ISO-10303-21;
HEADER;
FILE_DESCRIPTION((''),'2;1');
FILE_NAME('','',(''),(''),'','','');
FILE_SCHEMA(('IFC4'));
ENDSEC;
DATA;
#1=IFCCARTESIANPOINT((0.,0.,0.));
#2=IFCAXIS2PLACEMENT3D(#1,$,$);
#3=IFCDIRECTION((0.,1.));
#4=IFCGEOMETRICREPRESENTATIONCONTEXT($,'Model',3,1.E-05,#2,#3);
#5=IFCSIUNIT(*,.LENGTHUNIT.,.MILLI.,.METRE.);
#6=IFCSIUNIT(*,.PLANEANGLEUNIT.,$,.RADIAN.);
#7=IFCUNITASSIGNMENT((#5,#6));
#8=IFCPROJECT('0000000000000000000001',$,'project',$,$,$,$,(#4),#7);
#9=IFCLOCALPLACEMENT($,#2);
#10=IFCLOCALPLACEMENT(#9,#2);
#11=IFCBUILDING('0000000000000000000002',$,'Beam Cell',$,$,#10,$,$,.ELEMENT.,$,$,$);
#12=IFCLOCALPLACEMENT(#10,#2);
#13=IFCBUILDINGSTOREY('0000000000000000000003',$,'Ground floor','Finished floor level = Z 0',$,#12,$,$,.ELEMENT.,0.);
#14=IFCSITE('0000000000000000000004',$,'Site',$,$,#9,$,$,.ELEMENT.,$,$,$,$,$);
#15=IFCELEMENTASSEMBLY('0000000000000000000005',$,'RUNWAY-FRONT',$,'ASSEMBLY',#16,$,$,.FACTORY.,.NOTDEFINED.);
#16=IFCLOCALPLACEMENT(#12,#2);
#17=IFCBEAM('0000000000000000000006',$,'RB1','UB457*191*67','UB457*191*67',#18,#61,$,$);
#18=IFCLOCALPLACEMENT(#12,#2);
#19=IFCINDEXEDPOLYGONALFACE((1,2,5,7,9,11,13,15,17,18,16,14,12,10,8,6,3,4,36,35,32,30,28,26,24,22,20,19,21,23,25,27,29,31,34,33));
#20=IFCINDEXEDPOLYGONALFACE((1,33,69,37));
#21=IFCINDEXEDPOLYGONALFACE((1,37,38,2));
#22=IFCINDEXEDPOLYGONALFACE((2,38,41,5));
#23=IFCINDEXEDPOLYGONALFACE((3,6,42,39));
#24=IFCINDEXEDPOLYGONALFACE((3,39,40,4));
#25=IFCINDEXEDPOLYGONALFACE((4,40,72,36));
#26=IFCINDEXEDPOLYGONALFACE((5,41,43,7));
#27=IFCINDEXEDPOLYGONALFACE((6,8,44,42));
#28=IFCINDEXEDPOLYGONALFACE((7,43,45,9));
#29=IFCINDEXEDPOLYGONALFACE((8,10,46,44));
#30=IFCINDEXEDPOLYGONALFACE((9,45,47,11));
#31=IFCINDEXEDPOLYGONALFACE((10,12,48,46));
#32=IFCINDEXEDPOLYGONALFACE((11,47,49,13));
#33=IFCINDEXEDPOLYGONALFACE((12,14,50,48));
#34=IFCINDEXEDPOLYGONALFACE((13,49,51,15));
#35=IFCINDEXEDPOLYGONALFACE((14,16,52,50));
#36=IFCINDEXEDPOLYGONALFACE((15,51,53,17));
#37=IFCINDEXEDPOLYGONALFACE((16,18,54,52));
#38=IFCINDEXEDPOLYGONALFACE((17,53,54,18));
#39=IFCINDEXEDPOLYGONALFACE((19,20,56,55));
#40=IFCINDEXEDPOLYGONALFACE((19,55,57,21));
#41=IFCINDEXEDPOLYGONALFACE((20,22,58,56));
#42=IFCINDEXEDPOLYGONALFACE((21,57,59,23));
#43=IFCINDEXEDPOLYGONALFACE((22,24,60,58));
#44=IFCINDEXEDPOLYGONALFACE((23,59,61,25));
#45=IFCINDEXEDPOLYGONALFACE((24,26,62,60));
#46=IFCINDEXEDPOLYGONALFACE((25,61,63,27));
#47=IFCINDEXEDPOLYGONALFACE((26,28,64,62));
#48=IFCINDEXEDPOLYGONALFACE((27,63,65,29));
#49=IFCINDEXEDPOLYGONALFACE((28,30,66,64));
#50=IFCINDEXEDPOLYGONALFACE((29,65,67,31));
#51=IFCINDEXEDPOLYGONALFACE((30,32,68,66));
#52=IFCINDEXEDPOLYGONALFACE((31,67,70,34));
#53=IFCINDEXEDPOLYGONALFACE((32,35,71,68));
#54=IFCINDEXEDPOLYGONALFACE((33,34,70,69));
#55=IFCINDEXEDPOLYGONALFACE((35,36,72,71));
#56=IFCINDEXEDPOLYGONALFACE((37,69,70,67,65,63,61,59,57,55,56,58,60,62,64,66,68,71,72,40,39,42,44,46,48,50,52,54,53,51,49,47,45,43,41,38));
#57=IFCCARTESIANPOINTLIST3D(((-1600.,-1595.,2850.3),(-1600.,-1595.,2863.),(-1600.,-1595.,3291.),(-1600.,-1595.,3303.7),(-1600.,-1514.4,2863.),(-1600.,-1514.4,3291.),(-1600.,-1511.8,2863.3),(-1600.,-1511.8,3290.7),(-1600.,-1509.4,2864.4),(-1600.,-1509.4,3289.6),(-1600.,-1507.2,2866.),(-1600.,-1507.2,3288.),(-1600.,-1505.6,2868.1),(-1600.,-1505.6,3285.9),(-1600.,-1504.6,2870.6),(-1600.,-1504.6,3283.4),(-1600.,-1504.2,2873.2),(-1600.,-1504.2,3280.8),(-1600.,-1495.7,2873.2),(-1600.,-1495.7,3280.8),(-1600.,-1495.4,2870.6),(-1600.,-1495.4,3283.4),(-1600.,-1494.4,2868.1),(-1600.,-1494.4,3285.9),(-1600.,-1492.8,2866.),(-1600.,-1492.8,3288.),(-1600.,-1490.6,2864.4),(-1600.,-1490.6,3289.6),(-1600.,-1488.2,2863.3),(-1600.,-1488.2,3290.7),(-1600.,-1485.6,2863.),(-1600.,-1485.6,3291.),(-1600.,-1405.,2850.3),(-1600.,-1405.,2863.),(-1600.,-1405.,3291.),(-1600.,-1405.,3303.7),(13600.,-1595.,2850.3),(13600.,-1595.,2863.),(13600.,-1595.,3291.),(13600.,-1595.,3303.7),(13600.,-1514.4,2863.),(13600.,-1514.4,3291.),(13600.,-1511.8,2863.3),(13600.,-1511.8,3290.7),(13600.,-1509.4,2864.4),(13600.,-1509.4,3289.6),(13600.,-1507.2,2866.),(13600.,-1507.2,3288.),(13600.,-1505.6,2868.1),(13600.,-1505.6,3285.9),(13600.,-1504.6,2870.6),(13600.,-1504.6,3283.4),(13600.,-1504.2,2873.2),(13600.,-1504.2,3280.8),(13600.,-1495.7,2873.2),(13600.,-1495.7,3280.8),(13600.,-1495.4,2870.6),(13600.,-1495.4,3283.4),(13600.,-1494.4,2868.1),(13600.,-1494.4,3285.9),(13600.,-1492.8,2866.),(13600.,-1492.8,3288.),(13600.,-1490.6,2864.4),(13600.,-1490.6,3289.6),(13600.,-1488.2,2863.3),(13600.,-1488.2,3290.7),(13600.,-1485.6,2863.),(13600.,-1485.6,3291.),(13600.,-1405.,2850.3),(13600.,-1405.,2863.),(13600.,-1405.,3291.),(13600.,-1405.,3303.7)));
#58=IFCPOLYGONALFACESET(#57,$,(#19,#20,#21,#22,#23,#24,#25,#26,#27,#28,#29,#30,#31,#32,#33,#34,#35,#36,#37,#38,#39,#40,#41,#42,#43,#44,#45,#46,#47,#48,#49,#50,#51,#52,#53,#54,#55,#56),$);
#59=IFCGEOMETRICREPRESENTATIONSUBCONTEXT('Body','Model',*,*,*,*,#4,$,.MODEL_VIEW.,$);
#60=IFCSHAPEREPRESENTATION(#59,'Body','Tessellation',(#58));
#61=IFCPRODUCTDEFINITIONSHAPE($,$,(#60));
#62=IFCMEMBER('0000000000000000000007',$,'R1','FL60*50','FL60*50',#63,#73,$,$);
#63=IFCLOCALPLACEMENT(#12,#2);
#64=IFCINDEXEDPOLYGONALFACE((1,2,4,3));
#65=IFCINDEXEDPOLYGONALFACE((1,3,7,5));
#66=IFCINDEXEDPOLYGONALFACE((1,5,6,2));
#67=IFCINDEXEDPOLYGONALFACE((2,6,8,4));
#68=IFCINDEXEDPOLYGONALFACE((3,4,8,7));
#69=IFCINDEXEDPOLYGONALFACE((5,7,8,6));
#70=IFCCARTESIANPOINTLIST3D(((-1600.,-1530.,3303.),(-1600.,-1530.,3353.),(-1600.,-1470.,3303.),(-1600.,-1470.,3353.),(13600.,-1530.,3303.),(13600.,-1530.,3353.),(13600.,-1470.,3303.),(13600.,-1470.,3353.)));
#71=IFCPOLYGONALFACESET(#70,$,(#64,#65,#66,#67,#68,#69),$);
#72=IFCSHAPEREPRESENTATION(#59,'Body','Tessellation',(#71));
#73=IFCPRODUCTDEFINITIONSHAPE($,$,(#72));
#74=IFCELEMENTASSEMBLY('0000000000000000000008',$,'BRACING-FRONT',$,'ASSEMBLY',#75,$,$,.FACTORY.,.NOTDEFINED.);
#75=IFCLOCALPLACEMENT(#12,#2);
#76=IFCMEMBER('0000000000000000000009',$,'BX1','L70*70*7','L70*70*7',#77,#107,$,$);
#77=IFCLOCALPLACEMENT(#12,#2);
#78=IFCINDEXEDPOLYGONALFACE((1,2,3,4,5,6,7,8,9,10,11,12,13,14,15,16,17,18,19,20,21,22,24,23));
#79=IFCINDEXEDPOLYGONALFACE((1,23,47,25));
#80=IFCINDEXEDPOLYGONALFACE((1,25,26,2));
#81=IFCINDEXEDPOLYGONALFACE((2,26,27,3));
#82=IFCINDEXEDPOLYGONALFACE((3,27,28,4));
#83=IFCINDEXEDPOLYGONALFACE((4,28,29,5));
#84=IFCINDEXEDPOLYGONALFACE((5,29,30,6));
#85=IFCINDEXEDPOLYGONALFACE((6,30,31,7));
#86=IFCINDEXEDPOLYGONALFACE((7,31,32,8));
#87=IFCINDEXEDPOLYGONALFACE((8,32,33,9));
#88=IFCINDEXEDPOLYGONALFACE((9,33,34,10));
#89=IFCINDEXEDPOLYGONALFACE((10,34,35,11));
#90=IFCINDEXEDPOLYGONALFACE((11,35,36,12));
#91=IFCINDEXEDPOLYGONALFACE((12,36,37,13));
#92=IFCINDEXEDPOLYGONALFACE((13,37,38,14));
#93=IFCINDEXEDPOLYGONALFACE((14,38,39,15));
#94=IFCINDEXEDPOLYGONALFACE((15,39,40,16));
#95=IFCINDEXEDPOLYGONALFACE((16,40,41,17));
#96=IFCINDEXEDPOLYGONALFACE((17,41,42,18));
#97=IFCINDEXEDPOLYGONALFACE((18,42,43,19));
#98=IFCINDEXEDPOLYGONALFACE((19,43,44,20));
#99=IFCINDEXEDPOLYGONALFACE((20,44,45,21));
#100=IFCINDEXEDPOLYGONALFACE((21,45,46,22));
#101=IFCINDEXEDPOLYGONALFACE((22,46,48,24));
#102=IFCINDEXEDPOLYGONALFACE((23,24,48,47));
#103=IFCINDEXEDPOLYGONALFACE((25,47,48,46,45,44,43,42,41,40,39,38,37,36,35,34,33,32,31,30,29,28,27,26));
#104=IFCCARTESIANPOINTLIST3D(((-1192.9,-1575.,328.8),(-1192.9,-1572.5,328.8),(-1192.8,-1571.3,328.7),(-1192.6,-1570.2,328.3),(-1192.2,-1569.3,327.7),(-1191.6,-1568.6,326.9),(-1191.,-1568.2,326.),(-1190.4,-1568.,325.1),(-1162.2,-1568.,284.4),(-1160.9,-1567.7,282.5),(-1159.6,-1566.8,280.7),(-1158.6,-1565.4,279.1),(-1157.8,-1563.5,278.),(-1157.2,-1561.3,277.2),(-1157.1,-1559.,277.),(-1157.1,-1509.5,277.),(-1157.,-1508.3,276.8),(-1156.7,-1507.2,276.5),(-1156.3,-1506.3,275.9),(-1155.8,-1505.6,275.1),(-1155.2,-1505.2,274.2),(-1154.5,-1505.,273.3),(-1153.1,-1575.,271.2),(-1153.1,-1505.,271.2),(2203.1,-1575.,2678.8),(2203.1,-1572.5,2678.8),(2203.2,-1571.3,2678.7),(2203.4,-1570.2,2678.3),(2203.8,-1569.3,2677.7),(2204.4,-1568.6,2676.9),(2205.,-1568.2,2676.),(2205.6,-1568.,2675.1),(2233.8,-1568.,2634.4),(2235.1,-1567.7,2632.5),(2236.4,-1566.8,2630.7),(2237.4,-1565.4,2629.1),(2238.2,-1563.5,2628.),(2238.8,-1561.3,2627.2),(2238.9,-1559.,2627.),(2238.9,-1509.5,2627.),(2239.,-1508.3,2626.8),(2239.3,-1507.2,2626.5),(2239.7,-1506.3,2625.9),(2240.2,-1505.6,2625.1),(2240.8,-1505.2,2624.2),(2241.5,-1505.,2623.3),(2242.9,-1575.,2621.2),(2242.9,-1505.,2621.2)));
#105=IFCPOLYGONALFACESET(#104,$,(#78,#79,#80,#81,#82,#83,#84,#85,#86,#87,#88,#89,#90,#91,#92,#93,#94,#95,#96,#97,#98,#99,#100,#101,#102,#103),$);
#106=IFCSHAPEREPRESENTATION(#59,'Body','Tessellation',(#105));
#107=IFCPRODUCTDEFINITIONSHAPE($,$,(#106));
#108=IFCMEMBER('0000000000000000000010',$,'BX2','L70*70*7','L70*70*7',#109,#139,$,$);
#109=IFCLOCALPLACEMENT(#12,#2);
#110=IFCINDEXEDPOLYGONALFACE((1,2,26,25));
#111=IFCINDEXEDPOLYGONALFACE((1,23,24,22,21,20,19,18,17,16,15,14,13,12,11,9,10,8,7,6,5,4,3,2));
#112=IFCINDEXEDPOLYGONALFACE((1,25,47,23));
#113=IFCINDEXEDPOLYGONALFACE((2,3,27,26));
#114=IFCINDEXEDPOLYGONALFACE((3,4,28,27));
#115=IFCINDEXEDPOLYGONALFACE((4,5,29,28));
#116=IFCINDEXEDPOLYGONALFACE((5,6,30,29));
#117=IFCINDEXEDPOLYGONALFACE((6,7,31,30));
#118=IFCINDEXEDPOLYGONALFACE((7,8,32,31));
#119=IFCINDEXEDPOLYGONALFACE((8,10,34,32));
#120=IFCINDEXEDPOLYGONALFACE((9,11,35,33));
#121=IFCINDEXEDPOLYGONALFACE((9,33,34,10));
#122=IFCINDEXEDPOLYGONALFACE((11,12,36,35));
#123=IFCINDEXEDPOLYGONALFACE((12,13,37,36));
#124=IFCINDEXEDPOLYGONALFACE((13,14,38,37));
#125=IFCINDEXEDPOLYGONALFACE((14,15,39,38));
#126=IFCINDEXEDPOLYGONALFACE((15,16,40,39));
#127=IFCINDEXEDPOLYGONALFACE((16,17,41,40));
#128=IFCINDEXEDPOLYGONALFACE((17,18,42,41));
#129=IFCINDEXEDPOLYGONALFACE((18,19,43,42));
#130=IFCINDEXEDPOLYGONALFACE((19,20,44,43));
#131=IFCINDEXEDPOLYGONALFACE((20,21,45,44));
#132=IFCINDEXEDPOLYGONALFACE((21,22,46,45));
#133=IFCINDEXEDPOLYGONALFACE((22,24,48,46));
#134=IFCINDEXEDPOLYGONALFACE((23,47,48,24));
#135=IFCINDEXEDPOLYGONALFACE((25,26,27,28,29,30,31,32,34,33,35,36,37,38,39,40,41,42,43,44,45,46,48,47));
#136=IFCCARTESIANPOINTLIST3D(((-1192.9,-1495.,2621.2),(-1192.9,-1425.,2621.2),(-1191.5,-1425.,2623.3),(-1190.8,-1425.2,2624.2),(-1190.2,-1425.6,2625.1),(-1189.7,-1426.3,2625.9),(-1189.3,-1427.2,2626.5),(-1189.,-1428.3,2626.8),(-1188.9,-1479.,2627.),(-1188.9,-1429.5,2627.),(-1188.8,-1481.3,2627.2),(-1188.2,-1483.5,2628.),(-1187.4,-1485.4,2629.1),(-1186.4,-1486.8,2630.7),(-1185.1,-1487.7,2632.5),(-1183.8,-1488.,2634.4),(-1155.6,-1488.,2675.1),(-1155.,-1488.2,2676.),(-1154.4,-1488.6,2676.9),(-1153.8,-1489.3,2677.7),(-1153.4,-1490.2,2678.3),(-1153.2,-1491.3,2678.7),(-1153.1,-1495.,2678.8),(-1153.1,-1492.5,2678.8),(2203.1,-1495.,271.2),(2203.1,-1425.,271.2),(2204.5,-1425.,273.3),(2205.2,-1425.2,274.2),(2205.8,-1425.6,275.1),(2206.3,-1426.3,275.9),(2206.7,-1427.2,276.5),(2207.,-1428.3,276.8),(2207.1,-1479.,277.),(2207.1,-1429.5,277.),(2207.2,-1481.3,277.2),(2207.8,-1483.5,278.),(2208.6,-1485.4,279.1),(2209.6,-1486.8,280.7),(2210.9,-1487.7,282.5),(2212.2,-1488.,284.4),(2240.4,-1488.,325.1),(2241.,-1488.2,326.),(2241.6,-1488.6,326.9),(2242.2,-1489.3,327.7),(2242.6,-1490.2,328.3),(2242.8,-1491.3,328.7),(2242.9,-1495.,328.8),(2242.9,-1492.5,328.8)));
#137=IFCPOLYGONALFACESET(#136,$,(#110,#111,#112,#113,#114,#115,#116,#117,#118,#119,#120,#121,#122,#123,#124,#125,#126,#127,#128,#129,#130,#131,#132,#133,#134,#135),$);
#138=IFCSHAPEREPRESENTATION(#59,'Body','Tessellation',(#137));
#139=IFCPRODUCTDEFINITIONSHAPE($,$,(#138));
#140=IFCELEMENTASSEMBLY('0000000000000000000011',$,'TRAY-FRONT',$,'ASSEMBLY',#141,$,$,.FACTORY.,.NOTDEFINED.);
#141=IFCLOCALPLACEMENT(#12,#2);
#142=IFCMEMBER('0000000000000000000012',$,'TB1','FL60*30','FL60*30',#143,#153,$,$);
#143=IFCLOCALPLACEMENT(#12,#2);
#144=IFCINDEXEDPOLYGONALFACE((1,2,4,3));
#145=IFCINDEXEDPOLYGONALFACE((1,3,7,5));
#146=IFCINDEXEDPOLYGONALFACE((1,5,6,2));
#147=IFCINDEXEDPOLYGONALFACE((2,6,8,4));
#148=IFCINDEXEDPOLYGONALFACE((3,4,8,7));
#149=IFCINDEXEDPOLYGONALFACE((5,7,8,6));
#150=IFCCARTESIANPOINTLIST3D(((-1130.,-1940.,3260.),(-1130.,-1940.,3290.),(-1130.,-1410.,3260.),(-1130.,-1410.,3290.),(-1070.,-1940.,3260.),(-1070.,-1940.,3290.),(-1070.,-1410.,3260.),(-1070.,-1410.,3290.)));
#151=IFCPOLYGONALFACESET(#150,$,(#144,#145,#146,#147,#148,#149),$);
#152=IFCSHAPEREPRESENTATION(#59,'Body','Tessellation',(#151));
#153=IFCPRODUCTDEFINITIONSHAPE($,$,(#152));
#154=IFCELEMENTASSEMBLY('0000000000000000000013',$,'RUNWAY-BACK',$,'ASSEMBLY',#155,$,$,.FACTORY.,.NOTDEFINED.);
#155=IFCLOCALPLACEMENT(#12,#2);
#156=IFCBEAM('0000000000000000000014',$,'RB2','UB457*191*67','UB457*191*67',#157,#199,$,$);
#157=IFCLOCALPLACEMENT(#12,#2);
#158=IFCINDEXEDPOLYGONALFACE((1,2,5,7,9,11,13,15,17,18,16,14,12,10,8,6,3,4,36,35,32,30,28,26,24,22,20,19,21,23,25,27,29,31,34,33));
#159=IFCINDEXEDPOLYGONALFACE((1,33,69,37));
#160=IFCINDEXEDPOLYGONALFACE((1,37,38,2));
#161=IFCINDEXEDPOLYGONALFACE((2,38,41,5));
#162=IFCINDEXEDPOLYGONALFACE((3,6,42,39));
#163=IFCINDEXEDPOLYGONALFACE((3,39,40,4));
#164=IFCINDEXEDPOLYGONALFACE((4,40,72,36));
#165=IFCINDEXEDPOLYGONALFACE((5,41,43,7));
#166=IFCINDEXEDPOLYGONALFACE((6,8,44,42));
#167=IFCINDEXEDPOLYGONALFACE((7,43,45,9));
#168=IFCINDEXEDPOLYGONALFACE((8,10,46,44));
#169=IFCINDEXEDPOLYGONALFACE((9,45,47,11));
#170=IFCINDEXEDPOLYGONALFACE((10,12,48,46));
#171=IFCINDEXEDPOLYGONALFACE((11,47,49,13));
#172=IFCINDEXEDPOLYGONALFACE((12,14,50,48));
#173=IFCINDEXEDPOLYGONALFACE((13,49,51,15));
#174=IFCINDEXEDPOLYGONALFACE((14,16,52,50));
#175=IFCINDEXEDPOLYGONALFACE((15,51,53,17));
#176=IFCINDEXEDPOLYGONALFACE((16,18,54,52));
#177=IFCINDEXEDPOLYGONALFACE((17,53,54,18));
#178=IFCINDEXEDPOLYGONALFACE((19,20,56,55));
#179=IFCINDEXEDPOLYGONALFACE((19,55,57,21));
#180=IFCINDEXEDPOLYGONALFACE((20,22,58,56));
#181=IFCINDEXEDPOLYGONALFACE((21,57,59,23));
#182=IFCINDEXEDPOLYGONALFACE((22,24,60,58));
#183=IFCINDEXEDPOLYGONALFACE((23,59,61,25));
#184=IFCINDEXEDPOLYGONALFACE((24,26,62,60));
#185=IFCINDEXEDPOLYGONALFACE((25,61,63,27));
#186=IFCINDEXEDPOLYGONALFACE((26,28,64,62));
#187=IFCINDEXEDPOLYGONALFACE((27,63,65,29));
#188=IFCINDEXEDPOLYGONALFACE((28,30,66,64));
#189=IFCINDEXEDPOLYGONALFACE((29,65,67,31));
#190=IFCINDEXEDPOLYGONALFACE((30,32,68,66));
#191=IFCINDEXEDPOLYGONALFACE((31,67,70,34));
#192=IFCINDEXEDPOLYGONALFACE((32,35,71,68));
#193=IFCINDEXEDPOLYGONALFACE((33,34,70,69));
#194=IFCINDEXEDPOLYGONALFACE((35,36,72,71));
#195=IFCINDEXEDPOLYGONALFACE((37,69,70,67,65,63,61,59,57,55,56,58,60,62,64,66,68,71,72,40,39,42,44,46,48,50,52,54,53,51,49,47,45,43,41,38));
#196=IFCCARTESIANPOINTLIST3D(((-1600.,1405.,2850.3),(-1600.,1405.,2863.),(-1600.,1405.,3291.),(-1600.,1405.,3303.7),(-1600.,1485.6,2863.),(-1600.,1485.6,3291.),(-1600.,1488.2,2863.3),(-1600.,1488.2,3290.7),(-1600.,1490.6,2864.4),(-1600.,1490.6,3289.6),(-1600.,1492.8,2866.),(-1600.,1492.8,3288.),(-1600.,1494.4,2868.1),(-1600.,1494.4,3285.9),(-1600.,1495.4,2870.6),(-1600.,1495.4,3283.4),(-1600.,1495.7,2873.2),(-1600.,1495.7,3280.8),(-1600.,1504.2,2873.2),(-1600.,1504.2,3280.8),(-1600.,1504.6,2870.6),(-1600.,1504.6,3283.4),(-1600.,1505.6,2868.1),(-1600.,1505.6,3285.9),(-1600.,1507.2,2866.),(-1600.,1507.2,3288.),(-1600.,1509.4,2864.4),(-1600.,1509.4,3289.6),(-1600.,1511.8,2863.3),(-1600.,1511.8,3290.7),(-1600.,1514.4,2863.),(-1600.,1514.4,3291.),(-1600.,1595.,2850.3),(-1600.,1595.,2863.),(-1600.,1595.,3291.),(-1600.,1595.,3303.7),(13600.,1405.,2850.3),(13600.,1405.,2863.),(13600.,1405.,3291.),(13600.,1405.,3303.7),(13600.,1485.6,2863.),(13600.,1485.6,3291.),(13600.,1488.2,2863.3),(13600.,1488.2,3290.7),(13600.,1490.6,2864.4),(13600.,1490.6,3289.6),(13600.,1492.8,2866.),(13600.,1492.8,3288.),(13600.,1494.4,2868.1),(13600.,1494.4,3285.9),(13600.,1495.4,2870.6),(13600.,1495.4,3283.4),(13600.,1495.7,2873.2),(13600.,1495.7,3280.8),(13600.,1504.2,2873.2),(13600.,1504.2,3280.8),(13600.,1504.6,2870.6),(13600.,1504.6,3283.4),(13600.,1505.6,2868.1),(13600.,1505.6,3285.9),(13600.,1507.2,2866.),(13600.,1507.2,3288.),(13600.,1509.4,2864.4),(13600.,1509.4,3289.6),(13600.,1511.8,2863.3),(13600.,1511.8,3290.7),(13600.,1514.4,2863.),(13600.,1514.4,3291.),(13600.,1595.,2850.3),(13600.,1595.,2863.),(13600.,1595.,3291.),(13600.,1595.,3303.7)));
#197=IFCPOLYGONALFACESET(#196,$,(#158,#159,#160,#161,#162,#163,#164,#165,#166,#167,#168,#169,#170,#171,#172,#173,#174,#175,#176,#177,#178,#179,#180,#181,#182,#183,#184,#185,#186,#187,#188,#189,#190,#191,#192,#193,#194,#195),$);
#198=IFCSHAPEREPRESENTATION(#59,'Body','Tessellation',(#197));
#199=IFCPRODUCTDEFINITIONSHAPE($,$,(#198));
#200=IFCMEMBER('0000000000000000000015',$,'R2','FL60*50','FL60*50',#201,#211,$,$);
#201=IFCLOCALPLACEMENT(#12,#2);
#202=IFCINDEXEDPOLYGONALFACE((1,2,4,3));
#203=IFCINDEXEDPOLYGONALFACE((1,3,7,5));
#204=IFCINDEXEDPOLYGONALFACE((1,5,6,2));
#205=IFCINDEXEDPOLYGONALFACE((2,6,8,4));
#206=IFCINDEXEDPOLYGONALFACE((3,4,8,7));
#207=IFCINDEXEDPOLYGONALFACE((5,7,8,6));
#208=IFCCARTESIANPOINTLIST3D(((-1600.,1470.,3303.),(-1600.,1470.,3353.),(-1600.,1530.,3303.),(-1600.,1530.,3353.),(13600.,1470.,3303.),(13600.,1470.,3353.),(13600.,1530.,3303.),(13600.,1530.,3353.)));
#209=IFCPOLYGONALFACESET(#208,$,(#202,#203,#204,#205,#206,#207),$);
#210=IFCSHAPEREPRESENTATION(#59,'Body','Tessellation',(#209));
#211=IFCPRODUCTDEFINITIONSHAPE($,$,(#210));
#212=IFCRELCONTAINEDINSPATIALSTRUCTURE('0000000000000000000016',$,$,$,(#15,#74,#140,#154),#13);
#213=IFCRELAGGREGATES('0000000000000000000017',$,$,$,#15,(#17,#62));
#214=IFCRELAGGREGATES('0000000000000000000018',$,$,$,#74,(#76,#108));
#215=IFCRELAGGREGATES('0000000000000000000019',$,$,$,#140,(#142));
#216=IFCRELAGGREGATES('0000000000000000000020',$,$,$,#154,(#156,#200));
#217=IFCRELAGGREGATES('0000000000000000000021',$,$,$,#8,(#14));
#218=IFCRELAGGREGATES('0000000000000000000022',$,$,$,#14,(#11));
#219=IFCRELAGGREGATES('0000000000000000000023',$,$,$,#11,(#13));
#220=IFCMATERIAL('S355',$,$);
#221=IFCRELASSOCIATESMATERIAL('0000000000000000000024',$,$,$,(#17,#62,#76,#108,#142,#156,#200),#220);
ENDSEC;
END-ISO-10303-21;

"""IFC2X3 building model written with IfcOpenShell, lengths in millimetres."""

from ifc_helpers import new_model, si_unit, direction, frame, origin, origin_2d, place, context, subcontext, project, spatial, rectangle, i_section, l_section, extrude, material, element, aggregate, save


model = new_model("IFC2X3")

# Units and contexts
model_context = context("Model", 3, precision=1e-05, world=origin(), true_north=direction((0.0, 1.0)))
body_context = subcontext(model_context, "Body", "Model", "MODEL_VIEW")
ifc_project = project(units=[si_unit("LENGTHUNIT", "METRE", prefix="MILLI"), si_unit("PLANEANGLEUNIT", "RADIAN")], contexts=[model_context])

# Site, building, storey
site_placement = place(None, origin())
site = spatial("IfcSite", under=ifc_project, at=site_placement, Name="Site", CompositionType="ELEMENT")
building_placement = place(site_placement, origin())
building = spatial("IfcBuilding", under=site, at=building_placement, Name="Beam Cell", CompositionType="ELEMENT")
storey_placement = place(building_placement, origin())
storey = spatial("IfcBuildingStorey", under=building, at=storey_placement, Name="Ground floor", Description="Finished floor level = Z 0", CompositionType="ELEMENT", Elevation=0.0)

# Shared definitions
ifc_material = material(Name="S355")

# Element assembly, beam, member
assembly_1_placement = place(storey_placement, origin())
assembly_1 = element("IfcElementAssembly", 1, at=assembly_1_placement, inside=storey, Name="RUNWAY-FRONT", ObjectType="ASSEMBLY", AssemblyPlace="FACTORY", PredefinedType="NOTDEFINED")
beam_1_placement = place(storey_placement, frame((-1600.0, -1500.0, 3077.0), z_axis=(1.0, 0.0, 0.0), x_axis=(0.0, 1.0, 0.0)))
beam_1 = element("IfcBeam", 2, at=beam_1_placement, material=ifc_material, Name="RB1", Description="UB457*191*67", ObjectType="UB457*191*67", context=body_context, shape_type="SweptSolid", body=[
    extrude(i_section(OverallWidth=189.9, OverallDepth=453.4, WebThickness=8.5, FlangeThickness=12.7, FilletRadius=10.2, at=origin_2d()), origin(), (0.0, 0.0, 1.0), 15200.0),
])
member_1_placement = place(storey_placement, frame((-1600.0, -1500.0, 3328.0), z_axis=(1.0, 0.0, 0.0), x_axis=(0.0, 1.0, 0.0)))
member_1 = element("IfcMember", 3, at=member_1_placement, material=ifc_material, Name="R1", Description="FL60*50", ObjectType="FL60*50", context=body_context, shape_type="SweptSolid", body=[
    extrude(rectangle(XDim=60.0, YDim=50.0, at=origin_2d()), origin(), (0.0, 0.0, 1.0), 15200.0),
])
aggregate(assembly_1, [beam_1, member_1])

# Element assembly, members
assembly_2_placement = place(storey_placement, origin())
assembly_2 = element("IfcElementAssembly", 4, at=assembly_2_placement, inside=storey, Name="BRACING-FRONT", ObjectType="ASSEMBLY", AssemblyPlace="FACTORY", PredefinedType="NOTDEFINED")
member_2_placement = place(storey_placement, frame((-1173.0, -1540.0, 300.0), z_axis=(0.822314, 0.0, 0.569034), x_axis=(0.0, 1.0, 0.0)))
member_2 = element("IfcMember", 5, at=member_2_placement, material=ifc_material, Name="BX1", Description="L70*70*7", ObjectType="L70*70*7", context=body_context, shape_type="SweptSolid", body=[
    extrude(l_section(Depth=70.0, Width=70.0, Thickness=7.0, FilletRadius=9.0, EdgeRadius=4.5, at=origin_2d()), origin(), (0.0, 0.0, 1.0), 4129.8),
])
member_3_placement = place(storey_placement, frame((-1173.0, -1460.0, 2650.0), z_axis=(0.822314, 0.0, -0.569034), x_axis=(0.0, 1.0, 0.0)))
member_3 = element("IfcMember", 6, at=member_3_placement, material=ifc_material, Name="BX2", Description="L70*70*7", ObjectType="L70*70*7", context=body_context, shape_type="SweptSolid", body=[
    extrude(l_section(Depth=70.0, Width=70.0, Thickness=7.0, FilletRadius=9.0, EdgeRadius=4.5, at=origin_2d()), origin(), (0.0, 0.0, 1.0), 4129.8),
])
aggregate(assembly_2, [member_2, member_3])

# Element assembly, member
assembly_3_placement = place(storey_placement, origin())
assembly_3 = element("IfcElementAssembly", 7, at=assembly_3_placement, inside=storey, Name="TRAY-FRONT", ObjectType="ASSEMBLY", AssemblyPlace="FACTORY", PredefinedType="NOTDEFINED")
member_4_placement = place(storey_placement, frame((-1100.0, -1940.0, 3275.0), z_axis=(0.0, 1.0, 0.0), x_axis=(1.0, 0.0, 0.0)))
member_4 = element("IfcMember", 8, at=member_4_placement, material=ifc_material, Name="TB1", Description="FL60*30", ObjectType="FL60*30", context=body_context, shape_type="SweptSolid", body=[
    extrude(rectangle(XDim=60.0, YDim=30.0, at=origin_2d()), origin(), (0.0, 0.0, 1.0), 530.0),
])
aggregate(assembly_3, [member_4])

# Element assembly, beam, member
assembly_4_placement = place(storey_placement, origin())
assembly_4 = element("IfcElementAssembly", 9, at=assembly_4_placement, inside=storey, Name="RUNWAY-BACK", ObjectType="ASSEMBLY", AssemblyPlace="FACTORY", PredefinedType="NOTDEFINED")
beam_2_placement = place(storey_placement, frame((-1600.0, 1500.0, 3077.0), z_axis=(1.0, 0.0, 0.0), x_axis=(0.0, 1.0, 0.0)))
beam_2 = element("IfcBeam", 10, at=beam_2_placement, material=ifc_material, Name="RB2", Description="UB457*191*67", ObjectType="UB457*191*67", context=body_context, shape_type="SweptSolid", body=[
    extrude(i_section(OverallWidth=189.9, OverallDepth=453.4, WebThickness=8.5, FlangeThickness=12.7, FilletRadius=10.2, at=origin_2d()), origin(), (0.0, 0.0, 1.0), 15200.0),
])
member_5_placement = place(storey_placement, frame((-1600.0, 1500.0, 3328.0), z_axis=(1.0, 0.0, 0.0), x_axis=(0.0, 1.0, 0.0)))
member_5 = element("IfcMember", 11, at=member_5_placement, material=ifc_material, Name="R2", Description="FL60*50", ObjectType="FL60*50", context=body_context, shape_type="SweptSolid", body=[
    extrude(rectangle(XDim=60.0, YDim=50.0, at=origin_2d()), origin(), (0.0, 0.0, 1.0), 15200.0),
])
aggregate(assembly_4, [beam_2, member_5])

save(model, "model.ifc")
